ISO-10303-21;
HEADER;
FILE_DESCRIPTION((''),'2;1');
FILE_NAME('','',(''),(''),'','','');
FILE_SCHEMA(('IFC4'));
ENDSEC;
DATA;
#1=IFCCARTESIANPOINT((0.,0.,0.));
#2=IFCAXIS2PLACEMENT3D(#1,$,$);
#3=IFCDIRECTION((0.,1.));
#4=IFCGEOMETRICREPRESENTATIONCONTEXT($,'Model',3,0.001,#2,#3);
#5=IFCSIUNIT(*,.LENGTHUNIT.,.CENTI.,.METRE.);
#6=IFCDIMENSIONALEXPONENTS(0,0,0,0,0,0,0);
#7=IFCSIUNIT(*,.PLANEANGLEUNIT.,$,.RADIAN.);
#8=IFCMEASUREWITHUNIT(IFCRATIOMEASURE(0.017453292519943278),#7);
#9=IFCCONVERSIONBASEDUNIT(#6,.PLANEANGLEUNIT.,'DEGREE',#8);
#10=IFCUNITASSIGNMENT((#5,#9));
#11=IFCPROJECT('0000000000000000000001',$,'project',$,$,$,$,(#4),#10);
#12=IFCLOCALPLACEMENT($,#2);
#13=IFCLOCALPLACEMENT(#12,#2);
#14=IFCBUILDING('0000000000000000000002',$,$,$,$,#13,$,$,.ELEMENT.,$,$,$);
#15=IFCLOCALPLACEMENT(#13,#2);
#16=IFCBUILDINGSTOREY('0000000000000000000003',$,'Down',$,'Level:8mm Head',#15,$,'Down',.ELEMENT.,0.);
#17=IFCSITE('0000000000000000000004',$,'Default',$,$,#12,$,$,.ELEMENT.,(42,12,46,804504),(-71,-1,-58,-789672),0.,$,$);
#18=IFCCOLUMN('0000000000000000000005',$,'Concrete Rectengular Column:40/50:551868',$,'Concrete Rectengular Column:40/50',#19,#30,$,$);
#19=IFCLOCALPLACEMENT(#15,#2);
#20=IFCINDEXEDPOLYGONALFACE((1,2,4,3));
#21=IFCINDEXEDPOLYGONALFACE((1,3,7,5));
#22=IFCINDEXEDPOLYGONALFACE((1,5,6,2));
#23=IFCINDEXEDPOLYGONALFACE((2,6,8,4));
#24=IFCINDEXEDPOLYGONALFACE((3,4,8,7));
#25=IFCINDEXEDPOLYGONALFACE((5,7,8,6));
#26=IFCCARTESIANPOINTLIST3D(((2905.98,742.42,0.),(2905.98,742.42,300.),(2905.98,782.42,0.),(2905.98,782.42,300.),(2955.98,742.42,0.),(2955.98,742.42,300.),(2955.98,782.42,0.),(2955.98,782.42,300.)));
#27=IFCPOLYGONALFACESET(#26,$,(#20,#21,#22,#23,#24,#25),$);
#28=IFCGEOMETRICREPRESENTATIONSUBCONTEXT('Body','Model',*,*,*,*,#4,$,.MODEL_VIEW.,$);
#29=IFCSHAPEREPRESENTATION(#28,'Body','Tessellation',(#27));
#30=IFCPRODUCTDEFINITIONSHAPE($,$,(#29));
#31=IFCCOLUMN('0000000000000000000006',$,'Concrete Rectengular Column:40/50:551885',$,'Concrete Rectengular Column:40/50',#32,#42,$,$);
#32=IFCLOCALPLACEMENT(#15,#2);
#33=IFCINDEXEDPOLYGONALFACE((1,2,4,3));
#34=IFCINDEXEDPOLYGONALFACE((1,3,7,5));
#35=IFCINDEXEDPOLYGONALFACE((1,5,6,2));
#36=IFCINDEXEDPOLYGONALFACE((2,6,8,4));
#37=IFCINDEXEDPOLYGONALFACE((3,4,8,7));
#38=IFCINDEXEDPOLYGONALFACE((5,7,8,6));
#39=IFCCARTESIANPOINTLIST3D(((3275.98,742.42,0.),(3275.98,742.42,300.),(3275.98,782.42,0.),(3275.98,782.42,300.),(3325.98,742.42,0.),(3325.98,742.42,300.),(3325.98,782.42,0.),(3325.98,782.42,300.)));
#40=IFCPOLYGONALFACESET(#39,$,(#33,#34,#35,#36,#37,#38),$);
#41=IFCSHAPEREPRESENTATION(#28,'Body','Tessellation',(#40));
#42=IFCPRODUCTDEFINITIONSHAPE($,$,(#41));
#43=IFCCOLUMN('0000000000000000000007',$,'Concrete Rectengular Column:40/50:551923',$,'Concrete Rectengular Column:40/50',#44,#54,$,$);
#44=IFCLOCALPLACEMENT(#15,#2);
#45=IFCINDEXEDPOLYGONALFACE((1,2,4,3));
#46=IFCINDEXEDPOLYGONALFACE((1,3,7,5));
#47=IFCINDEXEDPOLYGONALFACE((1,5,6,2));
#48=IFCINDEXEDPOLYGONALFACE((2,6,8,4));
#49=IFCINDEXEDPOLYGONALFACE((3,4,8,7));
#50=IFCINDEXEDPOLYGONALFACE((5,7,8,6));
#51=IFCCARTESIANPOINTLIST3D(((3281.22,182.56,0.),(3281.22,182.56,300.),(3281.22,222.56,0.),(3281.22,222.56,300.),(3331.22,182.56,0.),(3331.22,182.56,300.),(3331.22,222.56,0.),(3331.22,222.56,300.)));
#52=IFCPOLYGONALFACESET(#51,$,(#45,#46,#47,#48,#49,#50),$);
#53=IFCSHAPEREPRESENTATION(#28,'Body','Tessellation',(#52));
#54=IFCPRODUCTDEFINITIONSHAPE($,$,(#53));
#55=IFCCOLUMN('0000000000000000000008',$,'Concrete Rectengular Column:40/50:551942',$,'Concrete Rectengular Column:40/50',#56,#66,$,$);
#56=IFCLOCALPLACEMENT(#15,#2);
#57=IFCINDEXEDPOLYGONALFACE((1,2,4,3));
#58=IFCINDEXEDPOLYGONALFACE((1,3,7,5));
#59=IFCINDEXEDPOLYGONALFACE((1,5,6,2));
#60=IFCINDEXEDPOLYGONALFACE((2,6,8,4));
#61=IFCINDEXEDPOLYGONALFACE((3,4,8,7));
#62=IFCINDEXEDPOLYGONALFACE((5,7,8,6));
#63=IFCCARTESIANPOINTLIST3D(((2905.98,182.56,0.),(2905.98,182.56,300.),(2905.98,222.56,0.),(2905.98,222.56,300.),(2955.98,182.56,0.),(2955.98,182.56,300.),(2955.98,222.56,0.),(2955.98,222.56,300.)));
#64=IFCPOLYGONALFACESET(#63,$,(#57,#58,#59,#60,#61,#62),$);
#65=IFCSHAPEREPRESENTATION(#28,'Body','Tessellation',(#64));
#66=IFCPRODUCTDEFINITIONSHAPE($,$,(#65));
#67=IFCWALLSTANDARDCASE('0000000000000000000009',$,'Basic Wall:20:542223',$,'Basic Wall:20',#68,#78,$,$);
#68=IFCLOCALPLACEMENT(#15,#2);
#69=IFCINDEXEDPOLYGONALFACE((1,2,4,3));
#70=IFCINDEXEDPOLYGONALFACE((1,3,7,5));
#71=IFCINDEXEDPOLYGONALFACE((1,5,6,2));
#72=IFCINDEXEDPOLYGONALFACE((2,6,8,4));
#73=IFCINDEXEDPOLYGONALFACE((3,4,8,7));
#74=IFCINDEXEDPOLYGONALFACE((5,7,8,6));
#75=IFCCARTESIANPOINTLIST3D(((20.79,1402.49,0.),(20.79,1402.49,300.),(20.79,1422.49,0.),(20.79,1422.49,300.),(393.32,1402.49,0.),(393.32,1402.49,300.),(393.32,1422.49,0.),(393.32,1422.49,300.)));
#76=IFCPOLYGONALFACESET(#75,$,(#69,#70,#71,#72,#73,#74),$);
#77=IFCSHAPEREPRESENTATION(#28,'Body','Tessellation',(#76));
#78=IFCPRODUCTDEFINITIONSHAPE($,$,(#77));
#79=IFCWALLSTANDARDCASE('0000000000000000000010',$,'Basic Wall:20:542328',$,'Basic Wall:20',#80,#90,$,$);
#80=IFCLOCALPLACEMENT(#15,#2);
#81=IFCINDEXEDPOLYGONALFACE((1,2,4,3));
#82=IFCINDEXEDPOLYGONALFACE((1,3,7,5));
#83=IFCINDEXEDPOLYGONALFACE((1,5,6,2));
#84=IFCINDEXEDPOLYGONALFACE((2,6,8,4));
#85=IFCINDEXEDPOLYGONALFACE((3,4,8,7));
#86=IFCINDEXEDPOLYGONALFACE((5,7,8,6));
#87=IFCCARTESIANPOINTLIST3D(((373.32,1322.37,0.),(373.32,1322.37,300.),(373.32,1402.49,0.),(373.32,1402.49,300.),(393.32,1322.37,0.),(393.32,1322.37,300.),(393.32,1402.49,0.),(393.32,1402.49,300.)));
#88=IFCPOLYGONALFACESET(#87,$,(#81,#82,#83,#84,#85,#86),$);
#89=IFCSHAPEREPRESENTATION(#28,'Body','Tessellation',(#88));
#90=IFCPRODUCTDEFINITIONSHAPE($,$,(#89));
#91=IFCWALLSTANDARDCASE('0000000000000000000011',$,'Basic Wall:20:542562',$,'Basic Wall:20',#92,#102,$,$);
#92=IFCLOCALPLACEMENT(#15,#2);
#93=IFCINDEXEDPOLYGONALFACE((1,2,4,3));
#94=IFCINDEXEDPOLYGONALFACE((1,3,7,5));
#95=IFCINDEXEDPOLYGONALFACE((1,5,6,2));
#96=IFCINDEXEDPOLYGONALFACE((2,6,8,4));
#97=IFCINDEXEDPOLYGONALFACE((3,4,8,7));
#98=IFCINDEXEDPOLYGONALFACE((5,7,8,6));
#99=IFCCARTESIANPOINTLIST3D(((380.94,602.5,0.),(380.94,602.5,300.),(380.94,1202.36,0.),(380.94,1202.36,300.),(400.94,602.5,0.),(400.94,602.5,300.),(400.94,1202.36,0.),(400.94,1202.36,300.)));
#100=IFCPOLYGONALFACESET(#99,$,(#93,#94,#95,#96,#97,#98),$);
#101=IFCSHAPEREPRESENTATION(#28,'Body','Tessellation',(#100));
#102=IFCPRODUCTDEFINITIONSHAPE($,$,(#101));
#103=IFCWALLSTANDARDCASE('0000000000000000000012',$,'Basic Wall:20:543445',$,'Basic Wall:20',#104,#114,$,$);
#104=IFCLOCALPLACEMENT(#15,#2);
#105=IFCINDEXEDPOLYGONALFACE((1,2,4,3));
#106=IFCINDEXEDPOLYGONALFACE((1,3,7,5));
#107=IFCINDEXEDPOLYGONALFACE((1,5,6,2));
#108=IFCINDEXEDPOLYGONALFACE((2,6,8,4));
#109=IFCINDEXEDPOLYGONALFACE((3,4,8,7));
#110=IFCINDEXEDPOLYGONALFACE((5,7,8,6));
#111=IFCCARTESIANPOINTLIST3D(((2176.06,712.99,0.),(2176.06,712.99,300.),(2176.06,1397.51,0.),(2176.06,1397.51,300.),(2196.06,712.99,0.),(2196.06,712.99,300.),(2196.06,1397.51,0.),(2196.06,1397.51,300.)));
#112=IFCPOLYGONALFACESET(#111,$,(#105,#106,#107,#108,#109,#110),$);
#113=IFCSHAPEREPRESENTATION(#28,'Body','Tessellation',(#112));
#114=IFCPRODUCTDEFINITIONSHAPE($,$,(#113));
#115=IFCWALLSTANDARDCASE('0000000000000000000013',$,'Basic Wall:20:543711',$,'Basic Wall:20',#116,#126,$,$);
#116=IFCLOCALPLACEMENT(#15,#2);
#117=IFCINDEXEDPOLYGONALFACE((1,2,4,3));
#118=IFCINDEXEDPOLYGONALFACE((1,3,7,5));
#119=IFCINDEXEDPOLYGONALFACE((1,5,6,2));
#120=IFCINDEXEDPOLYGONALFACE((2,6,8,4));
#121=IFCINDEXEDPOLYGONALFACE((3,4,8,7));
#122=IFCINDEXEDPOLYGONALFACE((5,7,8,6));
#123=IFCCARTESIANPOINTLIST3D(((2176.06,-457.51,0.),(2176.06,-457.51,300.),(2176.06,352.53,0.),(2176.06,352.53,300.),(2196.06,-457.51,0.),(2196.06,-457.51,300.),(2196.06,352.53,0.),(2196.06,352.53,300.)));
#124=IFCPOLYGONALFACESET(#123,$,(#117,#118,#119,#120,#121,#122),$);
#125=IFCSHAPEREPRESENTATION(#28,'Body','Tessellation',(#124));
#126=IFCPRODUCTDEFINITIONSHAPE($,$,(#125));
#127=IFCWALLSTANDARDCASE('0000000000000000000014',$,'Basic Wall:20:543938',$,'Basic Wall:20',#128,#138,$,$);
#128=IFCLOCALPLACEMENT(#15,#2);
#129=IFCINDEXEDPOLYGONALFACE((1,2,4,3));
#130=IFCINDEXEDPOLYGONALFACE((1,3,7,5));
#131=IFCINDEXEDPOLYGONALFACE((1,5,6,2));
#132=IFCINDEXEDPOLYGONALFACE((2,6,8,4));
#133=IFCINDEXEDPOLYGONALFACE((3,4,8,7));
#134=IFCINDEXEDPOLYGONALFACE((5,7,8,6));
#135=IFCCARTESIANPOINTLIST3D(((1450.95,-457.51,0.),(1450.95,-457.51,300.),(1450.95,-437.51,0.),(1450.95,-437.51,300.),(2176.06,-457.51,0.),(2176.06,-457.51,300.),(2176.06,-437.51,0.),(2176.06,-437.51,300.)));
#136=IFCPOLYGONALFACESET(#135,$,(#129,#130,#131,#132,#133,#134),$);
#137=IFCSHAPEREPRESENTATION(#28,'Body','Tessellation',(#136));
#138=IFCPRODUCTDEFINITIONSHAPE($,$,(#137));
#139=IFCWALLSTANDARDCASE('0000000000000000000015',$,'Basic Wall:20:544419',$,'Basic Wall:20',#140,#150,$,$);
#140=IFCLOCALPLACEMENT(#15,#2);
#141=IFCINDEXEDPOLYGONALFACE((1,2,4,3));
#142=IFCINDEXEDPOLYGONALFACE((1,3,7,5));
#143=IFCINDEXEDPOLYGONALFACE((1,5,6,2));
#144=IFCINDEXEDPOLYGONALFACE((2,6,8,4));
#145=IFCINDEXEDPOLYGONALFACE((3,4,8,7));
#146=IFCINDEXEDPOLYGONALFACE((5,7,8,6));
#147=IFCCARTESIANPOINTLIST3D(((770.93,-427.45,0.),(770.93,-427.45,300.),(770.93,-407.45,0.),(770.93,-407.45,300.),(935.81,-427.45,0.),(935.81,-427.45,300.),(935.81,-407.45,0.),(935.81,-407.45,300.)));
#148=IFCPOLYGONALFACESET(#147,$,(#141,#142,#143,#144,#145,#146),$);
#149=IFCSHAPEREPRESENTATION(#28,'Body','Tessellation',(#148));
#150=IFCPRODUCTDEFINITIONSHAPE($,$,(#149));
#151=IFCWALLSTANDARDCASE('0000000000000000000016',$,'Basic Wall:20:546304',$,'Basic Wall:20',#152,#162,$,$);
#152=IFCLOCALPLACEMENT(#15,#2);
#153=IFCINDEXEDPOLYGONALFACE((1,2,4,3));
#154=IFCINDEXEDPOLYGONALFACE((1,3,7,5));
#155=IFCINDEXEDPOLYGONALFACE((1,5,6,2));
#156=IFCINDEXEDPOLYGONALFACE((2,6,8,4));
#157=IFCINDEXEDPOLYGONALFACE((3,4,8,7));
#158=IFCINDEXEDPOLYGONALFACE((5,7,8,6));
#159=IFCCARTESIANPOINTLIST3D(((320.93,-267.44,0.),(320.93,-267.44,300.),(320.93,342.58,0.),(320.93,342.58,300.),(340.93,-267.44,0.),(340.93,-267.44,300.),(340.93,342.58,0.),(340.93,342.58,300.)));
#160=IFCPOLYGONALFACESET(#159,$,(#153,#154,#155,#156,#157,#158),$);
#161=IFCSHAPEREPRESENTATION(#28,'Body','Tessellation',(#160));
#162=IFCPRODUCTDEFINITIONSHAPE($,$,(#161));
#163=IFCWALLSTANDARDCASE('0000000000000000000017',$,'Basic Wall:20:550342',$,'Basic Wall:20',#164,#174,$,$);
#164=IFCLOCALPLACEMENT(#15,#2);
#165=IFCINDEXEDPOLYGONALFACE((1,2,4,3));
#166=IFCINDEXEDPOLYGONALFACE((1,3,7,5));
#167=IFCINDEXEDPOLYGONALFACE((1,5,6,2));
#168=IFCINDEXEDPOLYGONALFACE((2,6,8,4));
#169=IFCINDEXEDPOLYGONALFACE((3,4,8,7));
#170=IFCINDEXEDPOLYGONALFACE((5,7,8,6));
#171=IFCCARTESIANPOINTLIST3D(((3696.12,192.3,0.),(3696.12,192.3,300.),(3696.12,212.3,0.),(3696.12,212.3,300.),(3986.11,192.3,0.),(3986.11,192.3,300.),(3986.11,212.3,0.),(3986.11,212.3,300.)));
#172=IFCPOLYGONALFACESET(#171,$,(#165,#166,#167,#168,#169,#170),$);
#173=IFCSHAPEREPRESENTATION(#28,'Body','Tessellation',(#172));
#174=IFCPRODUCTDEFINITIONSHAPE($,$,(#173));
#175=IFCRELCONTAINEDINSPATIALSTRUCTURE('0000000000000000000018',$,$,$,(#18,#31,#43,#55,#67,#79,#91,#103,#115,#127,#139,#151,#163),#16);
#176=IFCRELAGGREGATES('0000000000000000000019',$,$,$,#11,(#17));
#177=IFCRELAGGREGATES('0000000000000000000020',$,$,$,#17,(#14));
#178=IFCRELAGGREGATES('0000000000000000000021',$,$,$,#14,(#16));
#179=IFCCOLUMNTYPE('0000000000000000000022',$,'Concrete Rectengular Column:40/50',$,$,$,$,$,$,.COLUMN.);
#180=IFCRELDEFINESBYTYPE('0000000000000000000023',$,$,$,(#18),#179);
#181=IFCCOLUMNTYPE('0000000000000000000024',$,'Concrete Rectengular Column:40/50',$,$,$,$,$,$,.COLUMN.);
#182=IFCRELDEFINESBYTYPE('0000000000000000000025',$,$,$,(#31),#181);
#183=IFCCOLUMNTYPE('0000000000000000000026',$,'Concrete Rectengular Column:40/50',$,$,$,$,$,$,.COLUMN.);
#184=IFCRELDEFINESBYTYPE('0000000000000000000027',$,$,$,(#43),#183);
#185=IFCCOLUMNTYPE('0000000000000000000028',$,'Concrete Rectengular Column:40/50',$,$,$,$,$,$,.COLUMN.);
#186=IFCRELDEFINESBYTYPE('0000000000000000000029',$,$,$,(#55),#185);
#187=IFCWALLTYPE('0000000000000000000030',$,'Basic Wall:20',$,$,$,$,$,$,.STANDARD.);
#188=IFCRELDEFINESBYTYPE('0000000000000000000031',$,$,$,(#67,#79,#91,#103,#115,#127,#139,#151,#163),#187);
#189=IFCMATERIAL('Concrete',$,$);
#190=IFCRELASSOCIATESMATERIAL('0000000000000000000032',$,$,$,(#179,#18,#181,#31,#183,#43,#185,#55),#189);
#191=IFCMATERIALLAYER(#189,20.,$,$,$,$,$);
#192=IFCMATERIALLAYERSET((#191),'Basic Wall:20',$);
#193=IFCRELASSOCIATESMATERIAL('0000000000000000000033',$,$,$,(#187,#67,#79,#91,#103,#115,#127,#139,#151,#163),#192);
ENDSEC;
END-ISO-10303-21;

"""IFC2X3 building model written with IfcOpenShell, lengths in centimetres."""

from ifc_helpers import new_model, entity, si_unit, converted_unit, direction, frame, frame_2d, origin, origin_2d_with_axis, place, context, subcontext, project, spatial, rectangle, extrude, source, transform, mapped, material, layer, layer_set, layer_usage, type_object, type_shapes, element, save


model = new_model("IFC2X3")

# Units and contexts
model_context = context("Model", 3, precision=0.001, world=origin(), true_north=direction((0.0, 1.0)))
body_context = subcontext(model_context, "Body", "Model", "MODEL_VIEW")
ifc_project = project(units=[si_unit("LENGTHUNIT", "METRE", prefix="CENTI"), converted_unit("PLANEANGLEUNIT", "DEGREE", entity("IfcRatioMeasure", 0.017453292519943278), si_unit("PLANEANGLEUNIT", "RADIAN"), dimensions=[0, 0, 0, 0, 0, 0, 0])], contexts=[model_context])

# Site, building, storey
site_placement = place(None, origin())
site = spatial("IfcSite", under=ifc_project, at=site_placement, Name="Default", CompositionType="ELEMENT", RefLatitude=(42, 12, 46, 804504), RefLongitude=(-71, -1, -58, -789672), RefElevation=0.0)
building_placement = place(site_placement, origin())
building = spatial("IfcBuilding", under=site, at=building_placement, CompositionType="ELEMENT")
storey_placement = place(building_placement, origin())
storey = spatial("IfcBuildingStorey", under=building, at=storey_placement, Name="Down", ObjectType="Level:8mm Head", LongName="Down", CompositionType="ELEMENT", Elevation=0.0)

# Columns
ifc_material = material(Name="Concrete")
column_type_1 = type_object("IfcColumnType", Name="Concrete Rectengular Column:40/50", PredefinedType="COLUMN", material=ifc_material)
shared_shape_1 = source(origin(), body_context, "Body", "SweptSolid", [
    extrude(rectangle(XDim=40.0, YDim=50.0, at=origin_2d_with_axis()), frame((2930.98, 762.42, 0.0), z_axis=(0.0, 0.0, 1.0), x_axis=(0.0, -1.0, 0.0)), (0.0, 0.0, 1.0), 300.0),
])
type_shapes(column_type_1, [shared_shape_1])
column_1_placement = place(storey_placement, origin())
element("IfcColumn", 1, at=column_1_placement, inside=storey, type_object=column_type_1, material=ifc_material, Name="Concrete Rectengular Column:40/50:551868", ObjectType="Concrete Rectengular Column:40/50", context=body_context, shape_type="MappedRepresentation", body=[
    mapped(shared_shape_1, transform((0.0, 0.0, 0.0), scale=1.0)),
])
column_type_2 = type_object("IfcColumnType", Name="Concrete Rectengular Column:40/50", PredefinedType="COLUMN", material=ifc_material)
shared_shape_2 = source(origin(), body_context, "Body", "SweptSolid", [
    extrude(rectangle(XDim=40.0, YDim=50.0, at=origin_2d_with_axis()), frame((3300.98, 762.42, 0.0), z_axis=(0.0, 0.0, 1.0), x_axis=(0.0, -1.0, 0.0)), (0.0, 0.0, 1.0), 300.0),
])
type_shapes(column_type_2, [shared_shape_2])
column_2_placement = place(storey_placement, origin())
element("IfcColumn", 2, at=column_2_placement, inside=storey, type_object=column_type_2, material=ifc_material, Name="Concrete Rectengular Column:40/50:551885", ObjectType="Concrete Rectengular Column:40/50", context=body_context, shape_type="MappedRepresentation", body=[
    mapped(shared_shape_2, transform((0.0, 0.0, 0.0), scale=1.0)),
])
column_type_3 = type_object("IfcColumnType", Name="Concrete Rectengular Column:40/50", PredefinedType="COLUMN", material=ifc_material)
shared_shape_3 = source(origin(), body_context, "Body", "SweptSolid", [
    extrude(rectangle(XDim=40.0, YDim=50.0, at=frame_2d((0.0, 0.0), x_axis=(1.0, 0.0))), frame((3306.22, 202.56, 0.0), z_axis=(0.0, 0.0, 1.0), x_axis=(0.0, -1.0, 0.0)), (0.0, 0.0, 1.0), 300.0),
])
type_shapes(column_type_3, [shared_shape_3])
column_3_placement = place(storey_placement, origin())
element("IfcColumn", 3, at=column_3_placement, inside=storey, type_object=column_type_3, material=ifc_material, Name="Concrete Rectengular Column:40/50:551923", ObjectType="Concrete Rectengular Column:40/50", context=body_context, shape_type="MappedRepresentation", body=[
    mapped(shared_shape_3, transform((0.0, 0.0, 0.0), scale=1.0)),
])
column_type_4 = type_object("IfcColumnType", Name="Concrete Rectengular Column:40/50", PredefinedType="COLUMN", material=ifc_material)
shared_shape_4 = source(origin(), body_context, "Body", "SweptSolid", [
    extrude(rectangle(XDim=40.0, YDim=50.0, at=origin_2d_with_axis()), frame((2930.98, 202.56, 0.0), z_axis=(0.0, 0.0, 1.0), x_axis=(0.0, -1.0, 0.0)), (0.0, 0.0, 1.0), 300.0),
])
type_shapes(column_type_4, [shared_shape_4])
column_4_placement = place(storey_placement, origin())
element("IfcColumn", 4, at=column_4_placement, inside=storey, type_object=column_type_4, material=ifc_material, Name="Concrete Rectengular Column:40/50:551942", ObjectType="Concrete Rectengular Column:40/50", context=body_context, shape_type="MappedRepresentation", body=[
    mapped(shared_shape_4, transform((0.0, 0.0, 0.0), scale=1.0)),
])

# Walls
ifc_layer_1 = layer(ifc_material, 20.0)
ifc_layer_set_1 = layer_set([ifc_layer_1], Name="Basic Wall:20")
ifc_layer_usage_1 = layer_usage(ifc_layer_set_1, "AXIS2", "POSITIVE", -10.0)
wall_type_1 = type_object("IfcWallType", Name="Basic Wall:20", PredefinedType="STANDARD", material=ifc_layer_set_1)
wall_1_placement = place(storey_placement, frame((20.79, 1412.49, 0.0)))
element("IfcWallStandardCase", 5, at=wall_1_placement, inside=storey, type_object=wall_type_1, material=ifc_layer_usage_1, Name="Basic Wall:20:542223", ObjectType="Basic Wall:20", context=body_context, shape_type="SweptSolid", body=[
    extrude(rectangle(XDim=372.53, YDim=20.0, at=frame_2d((186.26, 0.0), x_axis=(-1.0, 0.0))), origin(), (0.0, 0.0, 1.0), 300.0),
])
ifc_layer_usage_2 = layer_usage(ifc_layer_set_1, "AXIS2", "NEGATIVE", 10.0)
wall_2_placement = place(storey_placement, frame((383.32, 1402.49, 0.0), z_axis=(0.0, 0.0, 1.0), x_axis=(0.0, -1.0, 0.0)))
element("IfcWallStandardCase", 6, at=wall_2_placement, inside=storey, type_object=wall_type_1, material=ifc_layer_usage_2, Name="Basic Wall:20:542328", ObjectType="Basic Wall:20", context=body_context, shape_type="SweptSolid", body=[
    extrude(rectangle(XDim=80.12, YDim=20.0, at=frame_2d((40.06, 0.0), x_axis=(-1.0, 0.0))), origin(), (0.0, 0.0, 1.0), 300.0),
])
ifc_layer_usage_3 = layer_usage(ifc_layer_set_1, "AXIS2", "NEGATIVE", 10.0)
wall_3_placement = place(storey_placement, frame((390.94, 1202.36, 0.0), z_axis=(0.0, 0.0, 1.0), x_axis=(0.0, -1.0, 0.0)))
element("IfcWallStandardCase", 7, at=wall_3_placement, inside=storey, type_object=wall_type_1, material=ifc_layer_usage_3, Name="Basic Wall:20:542562", ObjectType="Basic Wall:20", context=body_context, shape_type="SweptSolid", body=[
    extrude(rectangle(XDim=599.86, YDim=20.0, at=frame_2d((299.93, 0.0), x_axis=(-1.0, 0.0))), origin(), (0.0, 0.0, 1.0), 300.0),
])
ifc_layer_usage_4 = layer_usage(ifc_layer_set_1, "AXIS2", "NEGATIVE", 10.0)
wall_4_placement = place(storey_placement, frame((2186.06, 1397.51, 0.0), z_axis=(0.0, 0.0, 1.0), x_axis=(0.0, -1.0, 0.0)))
element("IfcWallStandardCase", 8, at=wall_4_placement, inside=storey, type_object=wall_type_1, material=ifc_layer_usage_4, Name="Basic Wall:20:543445", ObjectType="Basic Wall:20", context=body_context, shape_type="SweptSolid", body=[
    extrude(rectangle(XDim=684.52, YDim=20.0, at=frame_2d((342.26, 0.0), x_axis=(-1.0, 0.0))), origin(), (0.0, 0.0, 1.0), 300.0),
])
ifc_layer_usage_5 = layer_usage(ifc_layer_set_1, "AXIS2", "NEGATIVE", 10.0)
wall_5_placement = place(storey_placement, frame((2186.06, 352.53, 0.0), z_axis=(0.0, 0.0, 1.0), x_axis=(0.0, -1.0, 0.0)))
element("IfcWallStandardCase", 9, at=wall_5_placement, inside=storey, type_object=wall_type_1, material=ifc_layer_usage_5, Name="Basic Wall:20:543711", ObjectType="Basic Wall:20", context=body_context, shape_type="SweptSolid", body=[
    extrude(rectangle(XDim=810.04, YDim=20.0, at=frame_2d((405.02, 0.0), x_axis=(-1.0, 0.0))), origin(), (0.0, 0.0, 1.0), 300.0),
])
ifc_layer_usage_6 = layer_usage(ifc_layer_set_1, "AXIS2", "NEGATIVE", 10.0)
wall_6_placement = place(storey_placement, frame((2176.06, -447.51, 0.0), z_axis=(0.0, 0.0, 1.0), x_axis=(-1.0, 0.0, 0.0)))
element("IfcWallStandardCase", 10, at=wall_6_placement, inside=storey, type_object=wall_type_1, material=ifc_layer_usage_6, Name="Basic Wall:20:543938", ObjectType="Basic Wall:20", context=body_context, shape_type="SweptSolid", body=[
    extrude(rectangle(XDim=725.11, YDim=20.0, at=frame_2d((362.56, 0.0), x_axis=(-1.0, 0.0))), origin(), (0.0, 0.0, 1.0), 300.0),
])
ifc_layer_usage_7 = layer_usage(ifc_layer_set_1, "AXIS2", "NEGATIVE", 10.0)
wall_7_placement = place(storey_placement, frame((935.81, -417.45, 0.0), z_axis=(0.0, 0.0, 1.0), x_axis=(-1.0, 0.0, 0.0)))
element("IfcWallStandardCase", 11, at=wall_7_placement, inside=storey, type_object=wall_type_1, material=ifc_layer_usage_7, Name="Basic Wall:20:544419", ObjectType="Basic Wall:20", context=body_context, shape_type="SweptSolid", body=[
    extrude(rectangle(XDim=164.89, YDim=20.0, at=frame_2d((82.44, 0.0), x_axis=(-1.0, 0.0))), origin(), (0.0, 0.0, 1.0), 300.0),
])
ifc_layer_usage_8 = layer_usage(ifc_layer_set_1, "AXIS2", "NEGATIVE", 10.0)
wall_8_placement = place(storey_placement, frame((330.93, -267.44, 0.0), z_axis=(0.0, 0.0, 1.0), x_axis=(0.0, 1.0, 0.0)))
element("IfcWallStandardCase", 12, at=wall_8_placement, inside=storey, type_object=wall_type_1, material=ifc_layer_usage_8, Name="Basic Wall:20:546304", ObjectType="Basic Wall:20", context=body_context, shape_type="SweptSolid", body=[
    extrude(rectangle(XDim=610.02, YDim=20.0, at=frame_2d((305.01, 0.0), x_axis=(-1.0, 0.0))), origin(), (0.0, 0.0, 1.0), 300.0),
])
ifc_layer_usage_9 = layer_usage(ifc_layer_set_1, "AXIS2", "NEGATIVE", 10.0)
wall_9_placement = place(storey_placement, frame((3986.11, 202.3, 0.0), z_axis=(0.0, 0.0, 1.0), x_axis=(-1.0, 0.0, 0.0)))
element("IfcWallStandardCase", 13, at=wall_9_placement, inside=storey, type_object=wall_type_1, material=ifc_layer_usage_9, Name="Basic Wall:20:550342", ObjectType="Basic Wall:20", context=body_context, shape_type="SweptSolid", body=[
    extrude(rectangle(XDim=289.98, YDim=20.0, at=frame_2d((144.99, 0.0), x_axis=(-1.0, 0.0))), origin(), (0.0, 0.0, 1.0), 300.0),
])

save(model, "model.ifc")
